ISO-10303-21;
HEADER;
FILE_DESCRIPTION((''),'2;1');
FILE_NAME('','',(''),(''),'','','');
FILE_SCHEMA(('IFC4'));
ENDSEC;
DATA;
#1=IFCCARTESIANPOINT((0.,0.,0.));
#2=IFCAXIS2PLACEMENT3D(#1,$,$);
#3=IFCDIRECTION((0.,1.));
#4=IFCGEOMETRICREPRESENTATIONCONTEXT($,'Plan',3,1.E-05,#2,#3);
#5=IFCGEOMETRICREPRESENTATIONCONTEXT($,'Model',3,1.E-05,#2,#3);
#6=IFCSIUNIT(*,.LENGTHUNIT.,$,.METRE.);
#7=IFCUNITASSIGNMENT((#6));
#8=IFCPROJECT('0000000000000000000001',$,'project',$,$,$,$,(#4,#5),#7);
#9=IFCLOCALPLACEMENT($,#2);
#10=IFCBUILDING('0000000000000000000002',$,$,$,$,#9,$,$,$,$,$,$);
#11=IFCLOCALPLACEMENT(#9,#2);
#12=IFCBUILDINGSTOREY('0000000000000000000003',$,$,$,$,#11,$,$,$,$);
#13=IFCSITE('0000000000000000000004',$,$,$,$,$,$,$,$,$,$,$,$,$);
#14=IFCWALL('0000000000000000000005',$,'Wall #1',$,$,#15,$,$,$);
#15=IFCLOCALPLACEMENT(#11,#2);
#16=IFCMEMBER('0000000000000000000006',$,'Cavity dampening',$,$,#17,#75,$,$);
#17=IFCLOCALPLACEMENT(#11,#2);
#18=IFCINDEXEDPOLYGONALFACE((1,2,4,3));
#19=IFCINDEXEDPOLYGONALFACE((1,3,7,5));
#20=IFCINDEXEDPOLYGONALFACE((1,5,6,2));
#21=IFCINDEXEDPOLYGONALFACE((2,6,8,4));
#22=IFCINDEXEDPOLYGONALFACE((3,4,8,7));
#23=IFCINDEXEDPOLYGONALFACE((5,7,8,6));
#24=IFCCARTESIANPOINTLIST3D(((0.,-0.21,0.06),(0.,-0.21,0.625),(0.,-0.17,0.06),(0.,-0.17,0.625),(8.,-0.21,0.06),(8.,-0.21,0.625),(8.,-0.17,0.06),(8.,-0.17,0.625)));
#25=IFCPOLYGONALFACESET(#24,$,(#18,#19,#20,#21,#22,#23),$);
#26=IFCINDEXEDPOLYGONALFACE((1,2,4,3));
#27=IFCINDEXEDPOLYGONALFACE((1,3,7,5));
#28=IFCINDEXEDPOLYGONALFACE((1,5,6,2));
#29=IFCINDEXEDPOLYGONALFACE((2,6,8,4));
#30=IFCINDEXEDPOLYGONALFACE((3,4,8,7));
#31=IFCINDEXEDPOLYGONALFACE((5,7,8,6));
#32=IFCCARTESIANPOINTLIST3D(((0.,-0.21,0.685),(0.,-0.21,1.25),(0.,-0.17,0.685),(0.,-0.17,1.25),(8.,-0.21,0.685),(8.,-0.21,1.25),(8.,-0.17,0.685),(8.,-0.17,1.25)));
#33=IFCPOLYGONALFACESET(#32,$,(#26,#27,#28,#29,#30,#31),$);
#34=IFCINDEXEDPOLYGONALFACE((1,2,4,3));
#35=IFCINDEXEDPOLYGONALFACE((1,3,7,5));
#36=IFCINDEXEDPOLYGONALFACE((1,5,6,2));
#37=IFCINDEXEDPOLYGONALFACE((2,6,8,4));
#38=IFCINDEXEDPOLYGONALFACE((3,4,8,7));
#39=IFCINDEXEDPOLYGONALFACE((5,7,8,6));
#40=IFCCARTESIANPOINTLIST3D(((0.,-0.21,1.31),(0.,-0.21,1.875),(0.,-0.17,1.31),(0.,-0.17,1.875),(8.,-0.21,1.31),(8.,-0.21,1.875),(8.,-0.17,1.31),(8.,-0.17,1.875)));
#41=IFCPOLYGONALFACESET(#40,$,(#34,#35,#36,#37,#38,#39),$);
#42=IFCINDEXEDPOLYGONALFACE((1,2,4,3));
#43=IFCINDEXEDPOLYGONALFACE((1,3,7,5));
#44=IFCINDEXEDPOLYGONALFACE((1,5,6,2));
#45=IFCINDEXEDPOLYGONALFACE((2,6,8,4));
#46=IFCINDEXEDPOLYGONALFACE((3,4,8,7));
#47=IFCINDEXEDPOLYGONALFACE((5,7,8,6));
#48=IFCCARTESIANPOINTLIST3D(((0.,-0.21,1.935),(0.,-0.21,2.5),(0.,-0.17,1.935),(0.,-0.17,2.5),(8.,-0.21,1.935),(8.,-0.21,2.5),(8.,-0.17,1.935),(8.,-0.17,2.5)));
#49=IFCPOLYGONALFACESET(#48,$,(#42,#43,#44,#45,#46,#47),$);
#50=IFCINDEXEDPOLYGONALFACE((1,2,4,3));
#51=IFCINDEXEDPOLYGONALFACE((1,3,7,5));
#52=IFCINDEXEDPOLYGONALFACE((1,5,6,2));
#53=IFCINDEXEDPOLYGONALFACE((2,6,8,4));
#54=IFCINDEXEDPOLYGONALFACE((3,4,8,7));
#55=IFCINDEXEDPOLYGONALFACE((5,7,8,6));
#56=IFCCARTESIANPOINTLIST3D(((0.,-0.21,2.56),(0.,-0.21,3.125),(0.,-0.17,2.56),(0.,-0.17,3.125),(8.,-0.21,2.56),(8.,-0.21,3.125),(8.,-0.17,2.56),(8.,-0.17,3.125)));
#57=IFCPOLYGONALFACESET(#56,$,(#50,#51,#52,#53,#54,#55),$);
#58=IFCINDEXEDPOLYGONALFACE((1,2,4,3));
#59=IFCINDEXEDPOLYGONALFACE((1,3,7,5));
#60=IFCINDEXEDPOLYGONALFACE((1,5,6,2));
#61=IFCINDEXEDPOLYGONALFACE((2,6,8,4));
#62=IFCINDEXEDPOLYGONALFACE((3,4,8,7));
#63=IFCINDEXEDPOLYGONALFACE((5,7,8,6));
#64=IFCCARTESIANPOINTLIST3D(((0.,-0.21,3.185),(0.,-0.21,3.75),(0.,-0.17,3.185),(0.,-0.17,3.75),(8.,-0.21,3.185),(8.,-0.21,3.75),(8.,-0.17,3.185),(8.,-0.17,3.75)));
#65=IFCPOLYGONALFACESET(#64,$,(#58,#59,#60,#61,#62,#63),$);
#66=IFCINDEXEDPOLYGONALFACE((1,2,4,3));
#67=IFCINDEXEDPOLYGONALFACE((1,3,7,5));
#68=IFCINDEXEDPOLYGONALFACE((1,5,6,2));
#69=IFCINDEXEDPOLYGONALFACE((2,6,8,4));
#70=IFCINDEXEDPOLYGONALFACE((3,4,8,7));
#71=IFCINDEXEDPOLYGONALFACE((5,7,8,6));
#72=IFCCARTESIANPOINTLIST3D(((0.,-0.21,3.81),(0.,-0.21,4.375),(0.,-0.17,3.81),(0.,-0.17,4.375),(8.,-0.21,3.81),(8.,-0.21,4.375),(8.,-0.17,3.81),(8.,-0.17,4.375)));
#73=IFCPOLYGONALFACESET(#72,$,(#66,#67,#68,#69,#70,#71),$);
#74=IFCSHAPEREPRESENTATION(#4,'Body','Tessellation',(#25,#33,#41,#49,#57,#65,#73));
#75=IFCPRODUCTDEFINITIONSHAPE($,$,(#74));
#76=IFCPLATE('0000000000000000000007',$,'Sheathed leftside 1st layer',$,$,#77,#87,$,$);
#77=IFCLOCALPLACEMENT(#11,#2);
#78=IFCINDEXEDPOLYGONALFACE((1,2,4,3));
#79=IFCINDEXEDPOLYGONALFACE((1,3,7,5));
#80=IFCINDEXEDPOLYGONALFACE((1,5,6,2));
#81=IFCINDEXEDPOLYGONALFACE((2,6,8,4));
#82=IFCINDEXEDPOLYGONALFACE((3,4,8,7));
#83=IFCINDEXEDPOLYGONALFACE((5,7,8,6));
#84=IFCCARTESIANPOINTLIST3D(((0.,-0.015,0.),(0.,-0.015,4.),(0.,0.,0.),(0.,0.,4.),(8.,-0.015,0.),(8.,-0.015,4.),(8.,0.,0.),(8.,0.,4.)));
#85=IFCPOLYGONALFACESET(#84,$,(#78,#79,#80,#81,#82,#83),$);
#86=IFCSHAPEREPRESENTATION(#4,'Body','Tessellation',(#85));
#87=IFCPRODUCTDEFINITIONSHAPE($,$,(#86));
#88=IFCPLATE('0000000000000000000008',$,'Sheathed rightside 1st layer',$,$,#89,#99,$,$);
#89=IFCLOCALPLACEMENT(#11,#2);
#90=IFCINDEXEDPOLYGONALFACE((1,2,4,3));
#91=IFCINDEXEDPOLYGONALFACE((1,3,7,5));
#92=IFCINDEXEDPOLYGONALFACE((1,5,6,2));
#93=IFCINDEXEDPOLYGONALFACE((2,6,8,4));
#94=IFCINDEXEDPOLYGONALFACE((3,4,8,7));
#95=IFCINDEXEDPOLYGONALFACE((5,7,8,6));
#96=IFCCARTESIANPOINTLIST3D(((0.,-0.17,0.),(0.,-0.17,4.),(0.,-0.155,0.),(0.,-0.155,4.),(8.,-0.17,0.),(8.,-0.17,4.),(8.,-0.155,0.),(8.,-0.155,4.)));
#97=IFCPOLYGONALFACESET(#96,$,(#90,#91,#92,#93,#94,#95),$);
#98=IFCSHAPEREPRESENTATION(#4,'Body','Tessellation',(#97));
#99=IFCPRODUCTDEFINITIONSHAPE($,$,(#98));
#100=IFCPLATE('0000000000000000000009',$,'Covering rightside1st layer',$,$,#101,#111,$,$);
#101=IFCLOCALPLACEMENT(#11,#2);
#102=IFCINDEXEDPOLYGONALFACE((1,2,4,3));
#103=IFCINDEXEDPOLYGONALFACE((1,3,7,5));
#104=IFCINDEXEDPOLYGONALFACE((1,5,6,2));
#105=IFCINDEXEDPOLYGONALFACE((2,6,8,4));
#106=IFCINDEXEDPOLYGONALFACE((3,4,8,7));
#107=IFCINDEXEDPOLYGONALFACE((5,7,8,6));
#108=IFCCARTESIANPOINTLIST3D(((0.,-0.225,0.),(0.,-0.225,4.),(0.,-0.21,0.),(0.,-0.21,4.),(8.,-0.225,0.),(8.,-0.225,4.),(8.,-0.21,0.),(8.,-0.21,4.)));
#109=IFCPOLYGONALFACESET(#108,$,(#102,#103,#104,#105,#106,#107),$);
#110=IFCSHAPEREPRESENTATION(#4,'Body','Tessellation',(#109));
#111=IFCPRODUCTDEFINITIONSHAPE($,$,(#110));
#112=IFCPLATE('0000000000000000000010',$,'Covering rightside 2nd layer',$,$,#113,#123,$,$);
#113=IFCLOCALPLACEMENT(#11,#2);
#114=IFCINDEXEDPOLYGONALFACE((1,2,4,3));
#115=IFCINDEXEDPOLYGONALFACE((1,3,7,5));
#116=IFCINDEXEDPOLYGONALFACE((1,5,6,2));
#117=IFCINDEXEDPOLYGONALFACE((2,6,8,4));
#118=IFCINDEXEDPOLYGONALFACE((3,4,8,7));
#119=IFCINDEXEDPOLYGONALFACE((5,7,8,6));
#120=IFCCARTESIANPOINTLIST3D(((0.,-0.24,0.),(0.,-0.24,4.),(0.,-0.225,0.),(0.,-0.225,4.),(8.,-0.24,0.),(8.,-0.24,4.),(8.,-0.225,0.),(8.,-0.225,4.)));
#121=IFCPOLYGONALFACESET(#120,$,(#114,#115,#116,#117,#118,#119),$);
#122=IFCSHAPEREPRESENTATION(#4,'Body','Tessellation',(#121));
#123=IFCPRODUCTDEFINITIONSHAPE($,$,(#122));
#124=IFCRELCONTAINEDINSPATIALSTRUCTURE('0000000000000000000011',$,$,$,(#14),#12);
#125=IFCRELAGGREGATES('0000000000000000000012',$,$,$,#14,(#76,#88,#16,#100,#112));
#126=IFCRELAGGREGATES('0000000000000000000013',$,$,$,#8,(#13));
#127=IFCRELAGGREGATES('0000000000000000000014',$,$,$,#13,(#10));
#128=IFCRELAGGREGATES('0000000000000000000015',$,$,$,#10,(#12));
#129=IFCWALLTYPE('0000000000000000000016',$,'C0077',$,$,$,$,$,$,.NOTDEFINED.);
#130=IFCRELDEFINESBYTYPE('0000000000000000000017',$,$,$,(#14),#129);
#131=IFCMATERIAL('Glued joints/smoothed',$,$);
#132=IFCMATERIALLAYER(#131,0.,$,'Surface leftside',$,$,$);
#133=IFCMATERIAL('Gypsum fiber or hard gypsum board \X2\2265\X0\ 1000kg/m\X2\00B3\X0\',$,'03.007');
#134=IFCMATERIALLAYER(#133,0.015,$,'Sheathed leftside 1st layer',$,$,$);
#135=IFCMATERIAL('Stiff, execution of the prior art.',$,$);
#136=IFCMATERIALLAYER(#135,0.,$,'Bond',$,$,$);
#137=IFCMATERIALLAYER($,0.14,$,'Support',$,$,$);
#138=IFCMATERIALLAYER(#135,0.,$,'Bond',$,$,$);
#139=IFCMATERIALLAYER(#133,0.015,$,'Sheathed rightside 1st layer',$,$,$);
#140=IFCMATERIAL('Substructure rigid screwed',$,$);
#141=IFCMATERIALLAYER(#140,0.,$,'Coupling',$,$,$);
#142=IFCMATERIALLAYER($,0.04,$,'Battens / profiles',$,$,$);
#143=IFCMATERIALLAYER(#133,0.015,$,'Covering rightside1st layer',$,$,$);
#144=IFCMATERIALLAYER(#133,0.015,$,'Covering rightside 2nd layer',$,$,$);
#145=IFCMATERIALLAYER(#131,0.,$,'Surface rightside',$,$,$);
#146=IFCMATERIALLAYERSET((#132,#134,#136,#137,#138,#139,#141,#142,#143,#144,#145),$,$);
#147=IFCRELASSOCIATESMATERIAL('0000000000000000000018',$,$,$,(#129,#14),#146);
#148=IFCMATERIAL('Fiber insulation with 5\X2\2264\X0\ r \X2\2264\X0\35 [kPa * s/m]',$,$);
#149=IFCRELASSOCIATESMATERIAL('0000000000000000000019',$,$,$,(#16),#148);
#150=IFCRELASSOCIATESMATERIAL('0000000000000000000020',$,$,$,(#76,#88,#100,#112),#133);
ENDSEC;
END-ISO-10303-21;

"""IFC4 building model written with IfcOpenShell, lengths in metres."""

from ifc_helpers import new_model, si_unit, direction, frame, frame_2d, origin, origin_with_axes, place, context, project, spatial, rectangle, extrude, material, layer, layer_set, type_object, element, aggregate, save


model = new_model("IFC4")

# Units and contexts
plan_context = context("Plan", 3, precision=1e-05, world=origin(), true_north=direction((0.0, 1.0)))
model_context = context("Model", 3, precision=1e-05, world=origin(), true_north=direction((0.0, 1.0)))
ifc_project = project(units=[si_unit("LENGTHUNIT", "METRE")], contexts=[plan_context, model_context])

# Site, building, storey
site = spatial("IfcSite", under=ifc_project)
building_placement = place(None, origin())
building = spatial("IfcBuilding", under=site, at=building_placement)
storey_placement = place(building_placement, origin())
storey = spatial("IfcBuildingStorey", under=building, at=storey_placement)

# Wall, member, plates
ifc_material_1 = material(Name="Glued joints/smoothed")
ifc_layer_1 = layer(ifc_material_1, 0.0, Name="Surface leftside")
ifc_material_2 = material(Name="Gypsum fiber or hard gypsum board ≥ 1000kg/m³", Category="03.007")
ifc_layer_2 = layer(ifc_material_2, 0.015, Name="Sheathed leftside 1st layer")
ifc_material_3 = material(Name="Stiff, execution of the prior art.")
ifc_layer_3 = layer(ifc_material_3, 0.0, Name="Bond")
ifc_layer_4 = layer(None, 0.14, Name="Support")
ifc_layer_5 = layer(ifc_material_3, 0.0, Name="Bond")
ifc_layer_6 = layer(ifc_material_2, 0.015, Name="Sheathed rightside 1st layer")
ifc_material_4 = material(Name="Substructure rigid screwed")
ifc_layer_7 = layer(ifc_material_4, 0.0, Name="Coupling")
ifc_layer_8 = layer(None, 0.04, Name="Battens / profiles")
ifc_layer_9 = layer(ifc_material_2, 0.015, Name="Covering rightside1st layer")
ifc_layer_10 = layer(ifc_material_2, 0.015, Name="Covering rightside 2nd layer")
ifc_layer_11 = layer(ifc_material_1, 0.0, Name="Surface rightside")
ifc_layer_set = layer_set([ifc_layer_1, ifc_layer_2, ifc_layer_3, ifc_layer_4, ifc_layer_5, ifc_layer_6, ifc_layer_7, ifc_layer_8, ifc_layer_9, ifc_layer_10, ifc_layer_11])
wall_type = type_object("IfcWallType", Name="C0077", PredefinedType="NOTDEFINED", material=ifc_layer_set)
wall_placement = place(None, frame((0.0, 0.0, 0.0), z_axis=(0.0, -1.0, 0.0), x_axis=(1.0, 0.0, 0.0)))
wall = element("IfcWall", 1, at=wall_placement, inside=storey, type_object=wall_type, material=ifc_layer_set, Name="Wall #1")
ifc_material_5 = material(Name="Fiber insulation with 5≤ r ≤35 [kPa * s/m]")
member_1_placement = place(wall_placement, origin())
member_1 = element("IfcMember", 2, at=member_1_placement, material=ifc_material_5, Name="Cavity dampening", context=plan_context, shape_type="SweptSolid", body=[
    extrude(rectangle(XDim=0.565, YDim=0.04, at=frame_2d((0.2825, 0.02), x_axis=(1.0, 0.0))), frame((0.0, 0.06, 0.17), z_axis=(1.0, 0.0, 0.0), x_axis=(0.0, 1.0, 0.0)), (0.0, 0.0, 1.0), 8.0),
    extrude(rectangle(XDim=0.565, YDim=0.04, at=frame_2d((0.2825, 0.02), x_axis=(1.0, 0.0))), frame((0.0, 0.685, 0.17), z_axis=(1.0, 0.0, 0.0), x_axis=(0.0, 1.0, 0.0)), (0.0, 0.0, 1.0), 8.0),
    extrude(rectangle(XDim=0.565, YDim=0.04, at=frame_2d((0.2825, 0.02), x_axis=(1.0, 0.0))), frame((0.0, 1.31, 0.17), z_axis=(1.0, 0.0, 0.0), x_axis=(0.0, 1.0, 0.0)), (0.0, 0.0, 1.0), 8.0),
    extrude(rectangle(XDim=0.565, YDim=0.04, at=frame_2d((0.2825, 0.02), x_axis=(1.0, 0.0))), frame((0.0, 1.935, 0.17), z_axis=(1.0, 0.0, 0.0), x_axis=(0.0, 1.0, 0.0)), (0.0, 0.0, 1.0), 8.0),
    extrude(rectangle(XDim=0.565, YDim=0.04, at=frame_2d((0.2825, 0.02), x_axis=(1.0, 0.0))), frame((0.0, 2.56, 0.17), z_axis=(1.0, 0.0, 0.0), x_axis=(0.0, 1.0, 0.0)), (0.0, 0.0, 1.0), 8.0),
    extrude(rectangle(XDim=0.565, YDim=0.04, at=frame_2d((0.2825, 0.02), x_axis=(1.0, 0.0))), frame((0.0, 3.185, 0.17), z_axis=(1.0, 0.0, 0.0), x_axis=(0.0, 1.0, 0.0)), (0.0, 0.0, 1.0), 8.0),
    extrude(rectangle(XDim=0.565, YDim=0.04, at=frame_2d((0.2825, 0.02), x_axis=(1.0, 0.0))), frame((0.0, 3.81, 0.17), z_axis=(1.0, 0.0, 0.0), x_axis=(0.0, 1.0, 0.0)), (0.0, 0.0, 1.0), 8.0),
])
plate_1_placement = place(wall_placement, origin())
plate_1 = element("IfcPlate", 3, at=plate_1_placement, material=ifc_material_2, Name="Sheathed leftside 1st layer", context=plan_context, shape_type="SweptSolid", body=[
    extrude(rectangle(XDim=8.0, YDim=4.0, at=frame_2d((4.0, 2.0), x_axis=(1.0, 0.0))), origin_with_axes(), (0.0, 0.0, 1.0), 0.015),
])
plate_2_placement = place(wall_placement, origin())
plate_2 = element("IfcPlate", 4, at=plate_2_placement, material=ifc_material_2, Name="Sheathed rightside 1st layer", context=plan_context, shape_type="SweptSolid", body=[
    extrude(rectangle(XDim=8.0, YDim=4.0, at=frame_2d((4.0, 2.0), x_axis=(1.0, 0.0))), frame((0.0, 0.0, 0.155), z_axis=(0.0, 0.0, 1.0), x_axis=(1.0, 0.0, 0.0)), (0.0, 0.0, 1.0), 0.015),
])
plate_3_placement = place(wall_placement, origin())
plate_3 = element("IfcPlate", 5, at=plate_3_placement, material=ifc_material_2, Name="Covering rightside1st layer", context=plan_context, shape_type="SweptSolid", body=[
    extrude(rectangle(XDim=8.0, YDim=4.0, at=frame_2d((4.0, 2.0), x_axis=(1.0, 0.0))), frame((0.0, 0.0, 0.21), z_axis=(0.0, 0.0, 1.0), x_axis=(1.0, 0.0, 0.0)), (0.0, 0.0, 1.0), 0.015),
])
plate_4_placement = place(wall_placement, origin())
plate_4 = element("IfcPlate", 6, at=plate_4_placement, material=ifc_material_2, Name="Covering rightside 2nd layer", context=plan_context, shape_type="SweptSolid", body=[
    extrude(rectangle(XDim=8.0, YDim=4.0, at=frame_2d((4.0, 2.0), x_axis=(1.0, 0.0))), frame((0.0, 0.0, 0.225), z_axis=(0.0, 0.0, 1.0), x_axis=(1.0, 0.0, 0.0)), (0.0, 0.0, 1.0), 0.015),
])
aggregate(wall, [plate_1, plate_2, member_1, plate_3, plate_4])

save(model, "model.ifc")
